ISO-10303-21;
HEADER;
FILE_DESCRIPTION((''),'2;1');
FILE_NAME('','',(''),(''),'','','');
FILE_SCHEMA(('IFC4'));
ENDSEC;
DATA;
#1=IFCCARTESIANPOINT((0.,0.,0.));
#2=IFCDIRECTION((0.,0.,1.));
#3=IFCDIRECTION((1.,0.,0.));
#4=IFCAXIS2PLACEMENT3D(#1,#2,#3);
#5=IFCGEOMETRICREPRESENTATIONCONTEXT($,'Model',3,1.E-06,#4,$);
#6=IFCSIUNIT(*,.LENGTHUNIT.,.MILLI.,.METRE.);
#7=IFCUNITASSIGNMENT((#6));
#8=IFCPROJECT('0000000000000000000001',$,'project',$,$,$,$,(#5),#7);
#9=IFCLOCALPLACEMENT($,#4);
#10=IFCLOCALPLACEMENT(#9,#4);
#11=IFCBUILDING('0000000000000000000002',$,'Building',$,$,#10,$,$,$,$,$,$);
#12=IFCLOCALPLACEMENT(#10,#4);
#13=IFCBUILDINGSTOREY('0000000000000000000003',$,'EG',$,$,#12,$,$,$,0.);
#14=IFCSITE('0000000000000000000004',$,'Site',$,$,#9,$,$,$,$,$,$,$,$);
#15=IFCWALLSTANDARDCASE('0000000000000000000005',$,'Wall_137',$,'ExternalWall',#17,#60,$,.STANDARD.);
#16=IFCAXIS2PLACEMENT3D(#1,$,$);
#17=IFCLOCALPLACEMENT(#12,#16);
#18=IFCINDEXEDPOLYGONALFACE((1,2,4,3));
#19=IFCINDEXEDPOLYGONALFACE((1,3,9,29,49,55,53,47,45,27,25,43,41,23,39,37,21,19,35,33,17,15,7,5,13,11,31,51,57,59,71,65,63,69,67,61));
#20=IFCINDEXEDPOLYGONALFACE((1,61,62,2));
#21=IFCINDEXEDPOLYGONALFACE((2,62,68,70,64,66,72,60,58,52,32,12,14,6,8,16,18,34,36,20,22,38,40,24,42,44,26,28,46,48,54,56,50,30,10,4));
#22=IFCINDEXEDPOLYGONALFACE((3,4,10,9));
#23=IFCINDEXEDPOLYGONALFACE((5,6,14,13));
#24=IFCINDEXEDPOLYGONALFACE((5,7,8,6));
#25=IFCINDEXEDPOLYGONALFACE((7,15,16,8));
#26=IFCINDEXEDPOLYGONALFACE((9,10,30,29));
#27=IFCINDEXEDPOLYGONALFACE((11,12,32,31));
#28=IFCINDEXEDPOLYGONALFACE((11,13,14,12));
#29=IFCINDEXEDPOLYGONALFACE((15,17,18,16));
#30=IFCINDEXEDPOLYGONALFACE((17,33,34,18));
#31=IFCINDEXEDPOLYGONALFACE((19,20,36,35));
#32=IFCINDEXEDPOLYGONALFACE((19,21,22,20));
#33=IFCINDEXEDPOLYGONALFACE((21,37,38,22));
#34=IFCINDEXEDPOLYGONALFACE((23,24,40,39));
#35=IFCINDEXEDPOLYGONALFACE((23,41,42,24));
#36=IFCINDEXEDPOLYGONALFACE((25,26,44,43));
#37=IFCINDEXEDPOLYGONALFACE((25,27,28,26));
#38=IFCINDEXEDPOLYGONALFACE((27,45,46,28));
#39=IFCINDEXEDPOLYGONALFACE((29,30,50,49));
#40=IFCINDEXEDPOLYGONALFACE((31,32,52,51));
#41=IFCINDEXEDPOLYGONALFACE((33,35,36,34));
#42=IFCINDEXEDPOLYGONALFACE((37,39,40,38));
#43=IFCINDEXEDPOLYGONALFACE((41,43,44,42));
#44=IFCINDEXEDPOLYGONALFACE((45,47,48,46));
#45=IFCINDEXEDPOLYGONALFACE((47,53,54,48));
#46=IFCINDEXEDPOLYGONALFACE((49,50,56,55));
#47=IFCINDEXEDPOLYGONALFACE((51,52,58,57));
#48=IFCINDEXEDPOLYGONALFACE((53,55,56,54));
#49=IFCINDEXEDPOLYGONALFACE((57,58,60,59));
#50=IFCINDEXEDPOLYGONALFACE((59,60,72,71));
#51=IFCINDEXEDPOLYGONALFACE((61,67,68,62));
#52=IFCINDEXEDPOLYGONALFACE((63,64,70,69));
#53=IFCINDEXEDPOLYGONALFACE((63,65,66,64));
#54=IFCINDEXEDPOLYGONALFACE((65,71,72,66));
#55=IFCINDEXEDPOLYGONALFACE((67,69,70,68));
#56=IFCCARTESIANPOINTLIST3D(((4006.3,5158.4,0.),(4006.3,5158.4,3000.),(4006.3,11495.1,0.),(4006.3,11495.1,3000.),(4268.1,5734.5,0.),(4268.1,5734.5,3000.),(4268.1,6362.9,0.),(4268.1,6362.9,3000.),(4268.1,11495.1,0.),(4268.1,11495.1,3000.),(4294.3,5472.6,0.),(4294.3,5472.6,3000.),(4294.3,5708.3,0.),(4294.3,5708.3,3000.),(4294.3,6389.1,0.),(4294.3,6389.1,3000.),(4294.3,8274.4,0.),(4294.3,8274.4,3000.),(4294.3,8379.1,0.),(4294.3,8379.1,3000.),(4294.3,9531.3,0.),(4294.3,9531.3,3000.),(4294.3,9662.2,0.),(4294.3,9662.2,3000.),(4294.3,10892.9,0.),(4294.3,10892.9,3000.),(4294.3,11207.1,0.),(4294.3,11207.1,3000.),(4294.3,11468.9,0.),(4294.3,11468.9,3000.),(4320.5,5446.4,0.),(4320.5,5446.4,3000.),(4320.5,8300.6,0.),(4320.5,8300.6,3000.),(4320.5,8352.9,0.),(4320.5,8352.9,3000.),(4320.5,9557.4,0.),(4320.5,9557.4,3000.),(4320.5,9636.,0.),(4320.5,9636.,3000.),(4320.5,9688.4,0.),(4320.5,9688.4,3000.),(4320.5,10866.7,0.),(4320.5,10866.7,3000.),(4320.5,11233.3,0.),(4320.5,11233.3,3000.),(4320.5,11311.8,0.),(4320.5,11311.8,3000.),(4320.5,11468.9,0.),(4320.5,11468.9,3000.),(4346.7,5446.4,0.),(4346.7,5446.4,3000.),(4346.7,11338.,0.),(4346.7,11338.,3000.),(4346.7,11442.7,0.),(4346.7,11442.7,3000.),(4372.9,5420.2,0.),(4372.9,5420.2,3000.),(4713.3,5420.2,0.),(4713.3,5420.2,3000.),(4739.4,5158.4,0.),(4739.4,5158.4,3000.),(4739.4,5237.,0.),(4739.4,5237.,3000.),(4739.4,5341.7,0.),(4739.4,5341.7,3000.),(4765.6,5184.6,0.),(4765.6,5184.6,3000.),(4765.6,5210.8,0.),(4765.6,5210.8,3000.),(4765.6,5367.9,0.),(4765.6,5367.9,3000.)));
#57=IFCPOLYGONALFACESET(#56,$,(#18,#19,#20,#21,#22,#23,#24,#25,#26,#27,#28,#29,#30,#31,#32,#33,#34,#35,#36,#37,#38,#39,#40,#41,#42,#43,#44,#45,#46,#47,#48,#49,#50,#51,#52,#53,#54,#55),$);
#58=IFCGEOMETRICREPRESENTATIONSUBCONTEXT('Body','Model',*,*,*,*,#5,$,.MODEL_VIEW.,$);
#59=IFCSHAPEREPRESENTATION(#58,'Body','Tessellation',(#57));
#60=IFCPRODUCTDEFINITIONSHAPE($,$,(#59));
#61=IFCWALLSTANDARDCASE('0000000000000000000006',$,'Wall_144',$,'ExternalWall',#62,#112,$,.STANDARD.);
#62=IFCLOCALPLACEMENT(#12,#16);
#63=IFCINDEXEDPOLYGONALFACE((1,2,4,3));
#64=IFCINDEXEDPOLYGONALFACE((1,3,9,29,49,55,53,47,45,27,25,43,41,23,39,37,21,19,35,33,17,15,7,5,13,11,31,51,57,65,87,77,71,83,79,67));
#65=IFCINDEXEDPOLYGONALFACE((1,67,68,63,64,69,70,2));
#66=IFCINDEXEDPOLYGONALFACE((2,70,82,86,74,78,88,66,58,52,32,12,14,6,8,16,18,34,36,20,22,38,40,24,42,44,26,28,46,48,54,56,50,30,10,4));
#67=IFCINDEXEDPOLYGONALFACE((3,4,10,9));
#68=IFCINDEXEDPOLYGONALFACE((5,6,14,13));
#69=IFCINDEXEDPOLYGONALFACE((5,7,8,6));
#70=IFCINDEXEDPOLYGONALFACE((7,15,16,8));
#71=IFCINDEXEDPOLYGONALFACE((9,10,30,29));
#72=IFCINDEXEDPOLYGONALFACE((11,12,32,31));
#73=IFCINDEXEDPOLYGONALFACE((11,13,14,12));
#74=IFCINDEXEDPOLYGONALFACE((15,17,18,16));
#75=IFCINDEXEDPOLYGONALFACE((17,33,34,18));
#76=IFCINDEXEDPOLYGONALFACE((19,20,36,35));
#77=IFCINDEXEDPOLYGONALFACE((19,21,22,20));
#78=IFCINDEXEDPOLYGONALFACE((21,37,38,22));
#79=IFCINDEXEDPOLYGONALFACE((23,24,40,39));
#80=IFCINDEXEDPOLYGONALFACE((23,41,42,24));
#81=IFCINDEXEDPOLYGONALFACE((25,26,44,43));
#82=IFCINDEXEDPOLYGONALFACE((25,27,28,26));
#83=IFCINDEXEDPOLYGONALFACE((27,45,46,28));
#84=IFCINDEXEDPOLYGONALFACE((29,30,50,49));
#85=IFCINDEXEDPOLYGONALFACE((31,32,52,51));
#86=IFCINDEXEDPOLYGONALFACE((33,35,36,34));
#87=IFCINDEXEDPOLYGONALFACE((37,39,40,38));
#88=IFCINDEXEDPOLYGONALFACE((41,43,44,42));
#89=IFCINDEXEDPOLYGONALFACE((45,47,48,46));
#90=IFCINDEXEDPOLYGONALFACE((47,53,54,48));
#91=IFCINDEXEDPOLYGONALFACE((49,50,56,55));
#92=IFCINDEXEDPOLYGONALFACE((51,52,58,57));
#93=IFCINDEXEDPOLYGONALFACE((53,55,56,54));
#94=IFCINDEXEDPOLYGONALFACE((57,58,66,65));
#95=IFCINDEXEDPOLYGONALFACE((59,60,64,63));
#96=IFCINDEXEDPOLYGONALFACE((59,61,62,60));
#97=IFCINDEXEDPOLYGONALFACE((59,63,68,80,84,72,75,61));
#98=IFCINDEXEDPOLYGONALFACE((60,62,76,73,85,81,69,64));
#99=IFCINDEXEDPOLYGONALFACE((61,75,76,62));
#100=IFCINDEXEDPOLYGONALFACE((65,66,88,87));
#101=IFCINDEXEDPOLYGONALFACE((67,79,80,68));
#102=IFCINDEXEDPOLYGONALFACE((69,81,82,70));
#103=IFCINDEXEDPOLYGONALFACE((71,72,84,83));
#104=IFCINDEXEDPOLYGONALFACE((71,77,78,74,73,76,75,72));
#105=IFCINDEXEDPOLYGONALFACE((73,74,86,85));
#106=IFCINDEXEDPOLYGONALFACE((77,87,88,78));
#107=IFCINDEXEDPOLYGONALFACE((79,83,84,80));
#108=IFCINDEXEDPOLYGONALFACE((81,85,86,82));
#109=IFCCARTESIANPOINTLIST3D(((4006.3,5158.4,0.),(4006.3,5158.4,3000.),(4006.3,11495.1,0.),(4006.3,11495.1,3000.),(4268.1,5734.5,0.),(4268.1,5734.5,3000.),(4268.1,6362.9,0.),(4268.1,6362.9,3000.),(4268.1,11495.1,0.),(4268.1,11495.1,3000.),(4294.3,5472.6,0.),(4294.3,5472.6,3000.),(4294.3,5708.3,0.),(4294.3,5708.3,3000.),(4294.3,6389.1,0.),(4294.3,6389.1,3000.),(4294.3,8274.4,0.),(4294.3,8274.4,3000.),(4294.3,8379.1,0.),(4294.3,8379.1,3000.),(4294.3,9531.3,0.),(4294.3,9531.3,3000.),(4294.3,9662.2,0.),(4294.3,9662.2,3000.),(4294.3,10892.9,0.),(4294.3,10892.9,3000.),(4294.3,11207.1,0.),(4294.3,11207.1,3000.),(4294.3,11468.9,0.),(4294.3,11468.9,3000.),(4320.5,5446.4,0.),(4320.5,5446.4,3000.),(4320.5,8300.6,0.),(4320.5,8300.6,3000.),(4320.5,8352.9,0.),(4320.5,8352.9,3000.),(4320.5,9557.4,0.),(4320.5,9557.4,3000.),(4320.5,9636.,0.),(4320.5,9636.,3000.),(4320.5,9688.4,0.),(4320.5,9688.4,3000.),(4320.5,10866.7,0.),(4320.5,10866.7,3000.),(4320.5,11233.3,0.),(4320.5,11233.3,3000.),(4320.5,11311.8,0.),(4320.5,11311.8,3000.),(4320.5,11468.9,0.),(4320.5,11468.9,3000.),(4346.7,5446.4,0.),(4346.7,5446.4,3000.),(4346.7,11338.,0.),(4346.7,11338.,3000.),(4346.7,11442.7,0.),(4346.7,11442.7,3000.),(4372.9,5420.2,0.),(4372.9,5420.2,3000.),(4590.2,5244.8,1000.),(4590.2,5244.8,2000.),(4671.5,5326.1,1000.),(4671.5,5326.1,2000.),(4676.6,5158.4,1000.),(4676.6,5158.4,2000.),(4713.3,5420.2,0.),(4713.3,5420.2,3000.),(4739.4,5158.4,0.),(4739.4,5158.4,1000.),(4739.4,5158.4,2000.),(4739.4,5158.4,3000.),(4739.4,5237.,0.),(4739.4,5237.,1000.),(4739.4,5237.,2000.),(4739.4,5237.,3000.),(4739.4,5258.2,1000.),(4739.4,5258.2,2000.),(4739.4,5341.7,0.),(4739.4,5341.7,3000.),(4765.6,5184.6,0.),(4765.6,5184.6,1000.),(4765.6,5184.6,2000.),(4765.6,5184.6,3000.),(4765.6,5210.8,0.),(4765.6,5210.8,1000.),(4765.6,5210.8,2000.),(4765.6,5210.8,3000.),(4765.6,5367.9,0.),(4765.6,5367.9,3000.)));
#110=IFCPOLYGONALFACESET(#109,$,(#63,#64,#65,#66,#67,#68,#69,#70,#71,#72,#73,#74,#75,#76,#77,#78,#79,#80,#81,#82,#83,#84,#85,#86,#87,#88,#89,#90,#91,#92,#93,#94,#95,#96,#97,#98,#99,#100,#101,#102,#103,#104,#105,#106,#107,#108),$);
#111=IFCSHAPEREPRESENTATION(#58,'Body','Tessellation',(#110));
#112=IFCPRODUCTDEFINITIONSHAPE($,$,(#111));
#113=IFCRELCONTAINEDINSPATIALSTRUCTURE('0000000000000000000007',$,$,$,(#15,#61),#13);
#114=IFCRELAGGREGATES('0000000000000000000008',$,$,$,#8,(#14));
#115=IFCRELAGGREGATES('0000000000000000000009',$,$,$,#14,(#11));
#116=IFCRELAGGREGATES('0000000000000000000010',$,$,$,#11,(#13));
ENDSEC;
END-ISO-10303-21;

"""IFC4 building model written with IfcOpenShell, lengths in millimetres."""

from ifc_helpers import new_model, si_unit, frame, origin_with_axes, place, context, subcontext, project, spatial, polyline, rectangle, outline, extrude, element, save


model = new_model("IFC4")

# Units and contexts
model_context = context("Model", 3, precision=1e-06, world=origin_with_axes())
body_context = subcontext(model_context, "Body", "Model", "MODEL_VIEW")
ifc_project = project(units=[si_unit("LENGTHUNIT", "METRE", prefix="MILLI")], contexts=[model_context])

# Site, building, storey
site_placement = place(None, origin_with_axes())
site = spatial("IfcSite", under=ifc_project, at=site_placement, Name="Site")
building_placement = place(site_placement, origin_with_axes())
building = spatial("IfcBuilding", under=site, at=building_placement, Name="Building")
storey_placement = place(building_placement, origin_with_axes())
storey = spatial("IfcBuildingStorey", under=building, at=storey_placement, Name="EG", Elevation=0.0)

# Wall
for number, where, z_axis, x_axis, name in (
    (1, (0.0, 0.0, 0.0), (0.0, 0.0, 1.0), (1.0, 0.0, 0.0), "Wall_137"),
):
    element("IfcWallStandardCase", number, at=place(storey_placement, frame(where, z_axis=z_axis, x_axis=x_axis)), inside=storey, Name=name, ObjectType="ExternalWall", PredefinedType="STANDARD", context=body_context, shape_type="SweptSolid", body=[
        extrude(outline(polyline([(4006.3, 5158.4, 0.0), (4006.3, 11495.1, 0.0), (4268.1, 11495.1, 0.0), (4294.3, 11468.9, 0.0), (4320.5, 11468.9, 0.0), (4346.7, 11442.7, 0.0), (4346.7, 11338.0, 0.0), (4320.5, 11311.8, 0.0), (4320.5, 11233.3, 0.0), (4294.3, 11207.1, 0.0), (4294.3, 10892.9, 0.0), (4320.5, 10866.7, 0.0), (4320.5, 9688.4, 0.0), (4294.3, 9662.2, 0.0), (4320.5, 9636.0, 0.0), (4320.5, 9557.4, 0.0), (4294.3, 9531.3, 0.0), (4294.3, 8379.1, 0.0), (4320.5, 8352.9, 0.0), (4320.5, 8300.6, 0.0), (4294.3, 8274.4, 0.0), (4294.3, 6389.1, 0.0), (4268.1, 6362.9, 0.0), (4268.1, 5734.5, 0.0), (4294.3, 5708.3, 0.0), (4294.3, 5472.6, 0.0), (4320.5, 5446.4, 0.0), (4346.7, 5446.4, 0.0), (4372.9, 5420.2, 0.0), (4713.3, 5420.2, 0.0), (4765.6, 5367.9, 0.0), (4739.4, 5341.7, 0.0), (4739.4, 5237.0, 0.0), (4765.6, 5210.8, 0.0), (4765.6, 5184.6, 0.0), (4739.4, 5158.4, 0.0), (4006.3, 5158.4, 0.0)])), origin_with_axes(), (0.0, 0.0, 1.0), 3000.0),
    ])

# Wall, opening
wall_1_placement = place(storey_placement, origin_with_axes())
wall_1 = element("IfcWallStandardCase", 2, at=wall_1_placement, inside=storey, Name="Wall_144", ObjectType="ExternalWall", PredefinedType="STANDARD", context=body_context, shape_type="SweptSolid", body=[
    extrude(outline(polyline([(4006.3, 5158.4, 0.0), (4006.3, 11495.1, 0.0), (4268.1, 11495.1, 0.0), (4294.3, 11468.9, 0.0), (4320.5, 11468.9, 0.0), (4346.7, 11442.7, 0.0), (4346.7, 11338.0, 0.0), (4320.5, 11311.8, 0.0), (4320.5, 11233.3, 0.0), (4294.3, 11207.1, 0.0), (4294.3, 10892.9, 0.0), (4320.5, 10866.7, 0.0), (4320.5, 9688.4, 0.0), (4294.3, 9662.2, 0.0), (4320.5, 9636.0, 0.0), (4320.5, 9557.4, 0.0), (4294.3, 9531.3, 0.0), (4294.3, 8379.1, 0.0), (4320.5, 8352.9, 0.0), (4320.5, 8300.6, 0.0), (4294.3, 8274.4, 0.0), (4294.3, 6389.1, 0.0), (4268.1, 6362.9, 0.0), (4268.1, 5734.5, 0.0), (4294.3, 5708.3, 0.0), (4294.3, 5472.6, 0.0), (4320.5, 5446.4, 0.0), (4346.7, 5446.4, 0.0), (4372.9, 5420.2, 0.0), (4713.3, 5420.2, 0.0), (4765.6, 5367.9, 0.0), (4739.4, 5341.7, 0.0), (4739.4, 5237.0, 0.0), (4765.6, 5210.8, 0.0), (4765.6, 5184.6, 0.0), (4739.4, 5158.4, 0.0), (4006.3, 5158.4, 0.0)])), origin_with_axes(), (0.0, 0.0, 1.0), 3000.0),
])
opening_1_placement = place(wall_1_placement, origin_with_axes())
element("IfcOpeningElement", 3, at=opening_1_placement, inside=storey, cuts=wall_1, context=body_context, shape_type="SweptSolid", body=[
    extrude(rectangle(XDim=2425.5, YDim=115.0), frame((5488.4, 4427.9, 1000.0), z_axis=(0.0, 0.0, 1.0), x_axis=(0.707107, -0.707107, 0.0)), (0.0, 0.0, 1.0), 1000.0),
])

save(model, "model.ifc")
